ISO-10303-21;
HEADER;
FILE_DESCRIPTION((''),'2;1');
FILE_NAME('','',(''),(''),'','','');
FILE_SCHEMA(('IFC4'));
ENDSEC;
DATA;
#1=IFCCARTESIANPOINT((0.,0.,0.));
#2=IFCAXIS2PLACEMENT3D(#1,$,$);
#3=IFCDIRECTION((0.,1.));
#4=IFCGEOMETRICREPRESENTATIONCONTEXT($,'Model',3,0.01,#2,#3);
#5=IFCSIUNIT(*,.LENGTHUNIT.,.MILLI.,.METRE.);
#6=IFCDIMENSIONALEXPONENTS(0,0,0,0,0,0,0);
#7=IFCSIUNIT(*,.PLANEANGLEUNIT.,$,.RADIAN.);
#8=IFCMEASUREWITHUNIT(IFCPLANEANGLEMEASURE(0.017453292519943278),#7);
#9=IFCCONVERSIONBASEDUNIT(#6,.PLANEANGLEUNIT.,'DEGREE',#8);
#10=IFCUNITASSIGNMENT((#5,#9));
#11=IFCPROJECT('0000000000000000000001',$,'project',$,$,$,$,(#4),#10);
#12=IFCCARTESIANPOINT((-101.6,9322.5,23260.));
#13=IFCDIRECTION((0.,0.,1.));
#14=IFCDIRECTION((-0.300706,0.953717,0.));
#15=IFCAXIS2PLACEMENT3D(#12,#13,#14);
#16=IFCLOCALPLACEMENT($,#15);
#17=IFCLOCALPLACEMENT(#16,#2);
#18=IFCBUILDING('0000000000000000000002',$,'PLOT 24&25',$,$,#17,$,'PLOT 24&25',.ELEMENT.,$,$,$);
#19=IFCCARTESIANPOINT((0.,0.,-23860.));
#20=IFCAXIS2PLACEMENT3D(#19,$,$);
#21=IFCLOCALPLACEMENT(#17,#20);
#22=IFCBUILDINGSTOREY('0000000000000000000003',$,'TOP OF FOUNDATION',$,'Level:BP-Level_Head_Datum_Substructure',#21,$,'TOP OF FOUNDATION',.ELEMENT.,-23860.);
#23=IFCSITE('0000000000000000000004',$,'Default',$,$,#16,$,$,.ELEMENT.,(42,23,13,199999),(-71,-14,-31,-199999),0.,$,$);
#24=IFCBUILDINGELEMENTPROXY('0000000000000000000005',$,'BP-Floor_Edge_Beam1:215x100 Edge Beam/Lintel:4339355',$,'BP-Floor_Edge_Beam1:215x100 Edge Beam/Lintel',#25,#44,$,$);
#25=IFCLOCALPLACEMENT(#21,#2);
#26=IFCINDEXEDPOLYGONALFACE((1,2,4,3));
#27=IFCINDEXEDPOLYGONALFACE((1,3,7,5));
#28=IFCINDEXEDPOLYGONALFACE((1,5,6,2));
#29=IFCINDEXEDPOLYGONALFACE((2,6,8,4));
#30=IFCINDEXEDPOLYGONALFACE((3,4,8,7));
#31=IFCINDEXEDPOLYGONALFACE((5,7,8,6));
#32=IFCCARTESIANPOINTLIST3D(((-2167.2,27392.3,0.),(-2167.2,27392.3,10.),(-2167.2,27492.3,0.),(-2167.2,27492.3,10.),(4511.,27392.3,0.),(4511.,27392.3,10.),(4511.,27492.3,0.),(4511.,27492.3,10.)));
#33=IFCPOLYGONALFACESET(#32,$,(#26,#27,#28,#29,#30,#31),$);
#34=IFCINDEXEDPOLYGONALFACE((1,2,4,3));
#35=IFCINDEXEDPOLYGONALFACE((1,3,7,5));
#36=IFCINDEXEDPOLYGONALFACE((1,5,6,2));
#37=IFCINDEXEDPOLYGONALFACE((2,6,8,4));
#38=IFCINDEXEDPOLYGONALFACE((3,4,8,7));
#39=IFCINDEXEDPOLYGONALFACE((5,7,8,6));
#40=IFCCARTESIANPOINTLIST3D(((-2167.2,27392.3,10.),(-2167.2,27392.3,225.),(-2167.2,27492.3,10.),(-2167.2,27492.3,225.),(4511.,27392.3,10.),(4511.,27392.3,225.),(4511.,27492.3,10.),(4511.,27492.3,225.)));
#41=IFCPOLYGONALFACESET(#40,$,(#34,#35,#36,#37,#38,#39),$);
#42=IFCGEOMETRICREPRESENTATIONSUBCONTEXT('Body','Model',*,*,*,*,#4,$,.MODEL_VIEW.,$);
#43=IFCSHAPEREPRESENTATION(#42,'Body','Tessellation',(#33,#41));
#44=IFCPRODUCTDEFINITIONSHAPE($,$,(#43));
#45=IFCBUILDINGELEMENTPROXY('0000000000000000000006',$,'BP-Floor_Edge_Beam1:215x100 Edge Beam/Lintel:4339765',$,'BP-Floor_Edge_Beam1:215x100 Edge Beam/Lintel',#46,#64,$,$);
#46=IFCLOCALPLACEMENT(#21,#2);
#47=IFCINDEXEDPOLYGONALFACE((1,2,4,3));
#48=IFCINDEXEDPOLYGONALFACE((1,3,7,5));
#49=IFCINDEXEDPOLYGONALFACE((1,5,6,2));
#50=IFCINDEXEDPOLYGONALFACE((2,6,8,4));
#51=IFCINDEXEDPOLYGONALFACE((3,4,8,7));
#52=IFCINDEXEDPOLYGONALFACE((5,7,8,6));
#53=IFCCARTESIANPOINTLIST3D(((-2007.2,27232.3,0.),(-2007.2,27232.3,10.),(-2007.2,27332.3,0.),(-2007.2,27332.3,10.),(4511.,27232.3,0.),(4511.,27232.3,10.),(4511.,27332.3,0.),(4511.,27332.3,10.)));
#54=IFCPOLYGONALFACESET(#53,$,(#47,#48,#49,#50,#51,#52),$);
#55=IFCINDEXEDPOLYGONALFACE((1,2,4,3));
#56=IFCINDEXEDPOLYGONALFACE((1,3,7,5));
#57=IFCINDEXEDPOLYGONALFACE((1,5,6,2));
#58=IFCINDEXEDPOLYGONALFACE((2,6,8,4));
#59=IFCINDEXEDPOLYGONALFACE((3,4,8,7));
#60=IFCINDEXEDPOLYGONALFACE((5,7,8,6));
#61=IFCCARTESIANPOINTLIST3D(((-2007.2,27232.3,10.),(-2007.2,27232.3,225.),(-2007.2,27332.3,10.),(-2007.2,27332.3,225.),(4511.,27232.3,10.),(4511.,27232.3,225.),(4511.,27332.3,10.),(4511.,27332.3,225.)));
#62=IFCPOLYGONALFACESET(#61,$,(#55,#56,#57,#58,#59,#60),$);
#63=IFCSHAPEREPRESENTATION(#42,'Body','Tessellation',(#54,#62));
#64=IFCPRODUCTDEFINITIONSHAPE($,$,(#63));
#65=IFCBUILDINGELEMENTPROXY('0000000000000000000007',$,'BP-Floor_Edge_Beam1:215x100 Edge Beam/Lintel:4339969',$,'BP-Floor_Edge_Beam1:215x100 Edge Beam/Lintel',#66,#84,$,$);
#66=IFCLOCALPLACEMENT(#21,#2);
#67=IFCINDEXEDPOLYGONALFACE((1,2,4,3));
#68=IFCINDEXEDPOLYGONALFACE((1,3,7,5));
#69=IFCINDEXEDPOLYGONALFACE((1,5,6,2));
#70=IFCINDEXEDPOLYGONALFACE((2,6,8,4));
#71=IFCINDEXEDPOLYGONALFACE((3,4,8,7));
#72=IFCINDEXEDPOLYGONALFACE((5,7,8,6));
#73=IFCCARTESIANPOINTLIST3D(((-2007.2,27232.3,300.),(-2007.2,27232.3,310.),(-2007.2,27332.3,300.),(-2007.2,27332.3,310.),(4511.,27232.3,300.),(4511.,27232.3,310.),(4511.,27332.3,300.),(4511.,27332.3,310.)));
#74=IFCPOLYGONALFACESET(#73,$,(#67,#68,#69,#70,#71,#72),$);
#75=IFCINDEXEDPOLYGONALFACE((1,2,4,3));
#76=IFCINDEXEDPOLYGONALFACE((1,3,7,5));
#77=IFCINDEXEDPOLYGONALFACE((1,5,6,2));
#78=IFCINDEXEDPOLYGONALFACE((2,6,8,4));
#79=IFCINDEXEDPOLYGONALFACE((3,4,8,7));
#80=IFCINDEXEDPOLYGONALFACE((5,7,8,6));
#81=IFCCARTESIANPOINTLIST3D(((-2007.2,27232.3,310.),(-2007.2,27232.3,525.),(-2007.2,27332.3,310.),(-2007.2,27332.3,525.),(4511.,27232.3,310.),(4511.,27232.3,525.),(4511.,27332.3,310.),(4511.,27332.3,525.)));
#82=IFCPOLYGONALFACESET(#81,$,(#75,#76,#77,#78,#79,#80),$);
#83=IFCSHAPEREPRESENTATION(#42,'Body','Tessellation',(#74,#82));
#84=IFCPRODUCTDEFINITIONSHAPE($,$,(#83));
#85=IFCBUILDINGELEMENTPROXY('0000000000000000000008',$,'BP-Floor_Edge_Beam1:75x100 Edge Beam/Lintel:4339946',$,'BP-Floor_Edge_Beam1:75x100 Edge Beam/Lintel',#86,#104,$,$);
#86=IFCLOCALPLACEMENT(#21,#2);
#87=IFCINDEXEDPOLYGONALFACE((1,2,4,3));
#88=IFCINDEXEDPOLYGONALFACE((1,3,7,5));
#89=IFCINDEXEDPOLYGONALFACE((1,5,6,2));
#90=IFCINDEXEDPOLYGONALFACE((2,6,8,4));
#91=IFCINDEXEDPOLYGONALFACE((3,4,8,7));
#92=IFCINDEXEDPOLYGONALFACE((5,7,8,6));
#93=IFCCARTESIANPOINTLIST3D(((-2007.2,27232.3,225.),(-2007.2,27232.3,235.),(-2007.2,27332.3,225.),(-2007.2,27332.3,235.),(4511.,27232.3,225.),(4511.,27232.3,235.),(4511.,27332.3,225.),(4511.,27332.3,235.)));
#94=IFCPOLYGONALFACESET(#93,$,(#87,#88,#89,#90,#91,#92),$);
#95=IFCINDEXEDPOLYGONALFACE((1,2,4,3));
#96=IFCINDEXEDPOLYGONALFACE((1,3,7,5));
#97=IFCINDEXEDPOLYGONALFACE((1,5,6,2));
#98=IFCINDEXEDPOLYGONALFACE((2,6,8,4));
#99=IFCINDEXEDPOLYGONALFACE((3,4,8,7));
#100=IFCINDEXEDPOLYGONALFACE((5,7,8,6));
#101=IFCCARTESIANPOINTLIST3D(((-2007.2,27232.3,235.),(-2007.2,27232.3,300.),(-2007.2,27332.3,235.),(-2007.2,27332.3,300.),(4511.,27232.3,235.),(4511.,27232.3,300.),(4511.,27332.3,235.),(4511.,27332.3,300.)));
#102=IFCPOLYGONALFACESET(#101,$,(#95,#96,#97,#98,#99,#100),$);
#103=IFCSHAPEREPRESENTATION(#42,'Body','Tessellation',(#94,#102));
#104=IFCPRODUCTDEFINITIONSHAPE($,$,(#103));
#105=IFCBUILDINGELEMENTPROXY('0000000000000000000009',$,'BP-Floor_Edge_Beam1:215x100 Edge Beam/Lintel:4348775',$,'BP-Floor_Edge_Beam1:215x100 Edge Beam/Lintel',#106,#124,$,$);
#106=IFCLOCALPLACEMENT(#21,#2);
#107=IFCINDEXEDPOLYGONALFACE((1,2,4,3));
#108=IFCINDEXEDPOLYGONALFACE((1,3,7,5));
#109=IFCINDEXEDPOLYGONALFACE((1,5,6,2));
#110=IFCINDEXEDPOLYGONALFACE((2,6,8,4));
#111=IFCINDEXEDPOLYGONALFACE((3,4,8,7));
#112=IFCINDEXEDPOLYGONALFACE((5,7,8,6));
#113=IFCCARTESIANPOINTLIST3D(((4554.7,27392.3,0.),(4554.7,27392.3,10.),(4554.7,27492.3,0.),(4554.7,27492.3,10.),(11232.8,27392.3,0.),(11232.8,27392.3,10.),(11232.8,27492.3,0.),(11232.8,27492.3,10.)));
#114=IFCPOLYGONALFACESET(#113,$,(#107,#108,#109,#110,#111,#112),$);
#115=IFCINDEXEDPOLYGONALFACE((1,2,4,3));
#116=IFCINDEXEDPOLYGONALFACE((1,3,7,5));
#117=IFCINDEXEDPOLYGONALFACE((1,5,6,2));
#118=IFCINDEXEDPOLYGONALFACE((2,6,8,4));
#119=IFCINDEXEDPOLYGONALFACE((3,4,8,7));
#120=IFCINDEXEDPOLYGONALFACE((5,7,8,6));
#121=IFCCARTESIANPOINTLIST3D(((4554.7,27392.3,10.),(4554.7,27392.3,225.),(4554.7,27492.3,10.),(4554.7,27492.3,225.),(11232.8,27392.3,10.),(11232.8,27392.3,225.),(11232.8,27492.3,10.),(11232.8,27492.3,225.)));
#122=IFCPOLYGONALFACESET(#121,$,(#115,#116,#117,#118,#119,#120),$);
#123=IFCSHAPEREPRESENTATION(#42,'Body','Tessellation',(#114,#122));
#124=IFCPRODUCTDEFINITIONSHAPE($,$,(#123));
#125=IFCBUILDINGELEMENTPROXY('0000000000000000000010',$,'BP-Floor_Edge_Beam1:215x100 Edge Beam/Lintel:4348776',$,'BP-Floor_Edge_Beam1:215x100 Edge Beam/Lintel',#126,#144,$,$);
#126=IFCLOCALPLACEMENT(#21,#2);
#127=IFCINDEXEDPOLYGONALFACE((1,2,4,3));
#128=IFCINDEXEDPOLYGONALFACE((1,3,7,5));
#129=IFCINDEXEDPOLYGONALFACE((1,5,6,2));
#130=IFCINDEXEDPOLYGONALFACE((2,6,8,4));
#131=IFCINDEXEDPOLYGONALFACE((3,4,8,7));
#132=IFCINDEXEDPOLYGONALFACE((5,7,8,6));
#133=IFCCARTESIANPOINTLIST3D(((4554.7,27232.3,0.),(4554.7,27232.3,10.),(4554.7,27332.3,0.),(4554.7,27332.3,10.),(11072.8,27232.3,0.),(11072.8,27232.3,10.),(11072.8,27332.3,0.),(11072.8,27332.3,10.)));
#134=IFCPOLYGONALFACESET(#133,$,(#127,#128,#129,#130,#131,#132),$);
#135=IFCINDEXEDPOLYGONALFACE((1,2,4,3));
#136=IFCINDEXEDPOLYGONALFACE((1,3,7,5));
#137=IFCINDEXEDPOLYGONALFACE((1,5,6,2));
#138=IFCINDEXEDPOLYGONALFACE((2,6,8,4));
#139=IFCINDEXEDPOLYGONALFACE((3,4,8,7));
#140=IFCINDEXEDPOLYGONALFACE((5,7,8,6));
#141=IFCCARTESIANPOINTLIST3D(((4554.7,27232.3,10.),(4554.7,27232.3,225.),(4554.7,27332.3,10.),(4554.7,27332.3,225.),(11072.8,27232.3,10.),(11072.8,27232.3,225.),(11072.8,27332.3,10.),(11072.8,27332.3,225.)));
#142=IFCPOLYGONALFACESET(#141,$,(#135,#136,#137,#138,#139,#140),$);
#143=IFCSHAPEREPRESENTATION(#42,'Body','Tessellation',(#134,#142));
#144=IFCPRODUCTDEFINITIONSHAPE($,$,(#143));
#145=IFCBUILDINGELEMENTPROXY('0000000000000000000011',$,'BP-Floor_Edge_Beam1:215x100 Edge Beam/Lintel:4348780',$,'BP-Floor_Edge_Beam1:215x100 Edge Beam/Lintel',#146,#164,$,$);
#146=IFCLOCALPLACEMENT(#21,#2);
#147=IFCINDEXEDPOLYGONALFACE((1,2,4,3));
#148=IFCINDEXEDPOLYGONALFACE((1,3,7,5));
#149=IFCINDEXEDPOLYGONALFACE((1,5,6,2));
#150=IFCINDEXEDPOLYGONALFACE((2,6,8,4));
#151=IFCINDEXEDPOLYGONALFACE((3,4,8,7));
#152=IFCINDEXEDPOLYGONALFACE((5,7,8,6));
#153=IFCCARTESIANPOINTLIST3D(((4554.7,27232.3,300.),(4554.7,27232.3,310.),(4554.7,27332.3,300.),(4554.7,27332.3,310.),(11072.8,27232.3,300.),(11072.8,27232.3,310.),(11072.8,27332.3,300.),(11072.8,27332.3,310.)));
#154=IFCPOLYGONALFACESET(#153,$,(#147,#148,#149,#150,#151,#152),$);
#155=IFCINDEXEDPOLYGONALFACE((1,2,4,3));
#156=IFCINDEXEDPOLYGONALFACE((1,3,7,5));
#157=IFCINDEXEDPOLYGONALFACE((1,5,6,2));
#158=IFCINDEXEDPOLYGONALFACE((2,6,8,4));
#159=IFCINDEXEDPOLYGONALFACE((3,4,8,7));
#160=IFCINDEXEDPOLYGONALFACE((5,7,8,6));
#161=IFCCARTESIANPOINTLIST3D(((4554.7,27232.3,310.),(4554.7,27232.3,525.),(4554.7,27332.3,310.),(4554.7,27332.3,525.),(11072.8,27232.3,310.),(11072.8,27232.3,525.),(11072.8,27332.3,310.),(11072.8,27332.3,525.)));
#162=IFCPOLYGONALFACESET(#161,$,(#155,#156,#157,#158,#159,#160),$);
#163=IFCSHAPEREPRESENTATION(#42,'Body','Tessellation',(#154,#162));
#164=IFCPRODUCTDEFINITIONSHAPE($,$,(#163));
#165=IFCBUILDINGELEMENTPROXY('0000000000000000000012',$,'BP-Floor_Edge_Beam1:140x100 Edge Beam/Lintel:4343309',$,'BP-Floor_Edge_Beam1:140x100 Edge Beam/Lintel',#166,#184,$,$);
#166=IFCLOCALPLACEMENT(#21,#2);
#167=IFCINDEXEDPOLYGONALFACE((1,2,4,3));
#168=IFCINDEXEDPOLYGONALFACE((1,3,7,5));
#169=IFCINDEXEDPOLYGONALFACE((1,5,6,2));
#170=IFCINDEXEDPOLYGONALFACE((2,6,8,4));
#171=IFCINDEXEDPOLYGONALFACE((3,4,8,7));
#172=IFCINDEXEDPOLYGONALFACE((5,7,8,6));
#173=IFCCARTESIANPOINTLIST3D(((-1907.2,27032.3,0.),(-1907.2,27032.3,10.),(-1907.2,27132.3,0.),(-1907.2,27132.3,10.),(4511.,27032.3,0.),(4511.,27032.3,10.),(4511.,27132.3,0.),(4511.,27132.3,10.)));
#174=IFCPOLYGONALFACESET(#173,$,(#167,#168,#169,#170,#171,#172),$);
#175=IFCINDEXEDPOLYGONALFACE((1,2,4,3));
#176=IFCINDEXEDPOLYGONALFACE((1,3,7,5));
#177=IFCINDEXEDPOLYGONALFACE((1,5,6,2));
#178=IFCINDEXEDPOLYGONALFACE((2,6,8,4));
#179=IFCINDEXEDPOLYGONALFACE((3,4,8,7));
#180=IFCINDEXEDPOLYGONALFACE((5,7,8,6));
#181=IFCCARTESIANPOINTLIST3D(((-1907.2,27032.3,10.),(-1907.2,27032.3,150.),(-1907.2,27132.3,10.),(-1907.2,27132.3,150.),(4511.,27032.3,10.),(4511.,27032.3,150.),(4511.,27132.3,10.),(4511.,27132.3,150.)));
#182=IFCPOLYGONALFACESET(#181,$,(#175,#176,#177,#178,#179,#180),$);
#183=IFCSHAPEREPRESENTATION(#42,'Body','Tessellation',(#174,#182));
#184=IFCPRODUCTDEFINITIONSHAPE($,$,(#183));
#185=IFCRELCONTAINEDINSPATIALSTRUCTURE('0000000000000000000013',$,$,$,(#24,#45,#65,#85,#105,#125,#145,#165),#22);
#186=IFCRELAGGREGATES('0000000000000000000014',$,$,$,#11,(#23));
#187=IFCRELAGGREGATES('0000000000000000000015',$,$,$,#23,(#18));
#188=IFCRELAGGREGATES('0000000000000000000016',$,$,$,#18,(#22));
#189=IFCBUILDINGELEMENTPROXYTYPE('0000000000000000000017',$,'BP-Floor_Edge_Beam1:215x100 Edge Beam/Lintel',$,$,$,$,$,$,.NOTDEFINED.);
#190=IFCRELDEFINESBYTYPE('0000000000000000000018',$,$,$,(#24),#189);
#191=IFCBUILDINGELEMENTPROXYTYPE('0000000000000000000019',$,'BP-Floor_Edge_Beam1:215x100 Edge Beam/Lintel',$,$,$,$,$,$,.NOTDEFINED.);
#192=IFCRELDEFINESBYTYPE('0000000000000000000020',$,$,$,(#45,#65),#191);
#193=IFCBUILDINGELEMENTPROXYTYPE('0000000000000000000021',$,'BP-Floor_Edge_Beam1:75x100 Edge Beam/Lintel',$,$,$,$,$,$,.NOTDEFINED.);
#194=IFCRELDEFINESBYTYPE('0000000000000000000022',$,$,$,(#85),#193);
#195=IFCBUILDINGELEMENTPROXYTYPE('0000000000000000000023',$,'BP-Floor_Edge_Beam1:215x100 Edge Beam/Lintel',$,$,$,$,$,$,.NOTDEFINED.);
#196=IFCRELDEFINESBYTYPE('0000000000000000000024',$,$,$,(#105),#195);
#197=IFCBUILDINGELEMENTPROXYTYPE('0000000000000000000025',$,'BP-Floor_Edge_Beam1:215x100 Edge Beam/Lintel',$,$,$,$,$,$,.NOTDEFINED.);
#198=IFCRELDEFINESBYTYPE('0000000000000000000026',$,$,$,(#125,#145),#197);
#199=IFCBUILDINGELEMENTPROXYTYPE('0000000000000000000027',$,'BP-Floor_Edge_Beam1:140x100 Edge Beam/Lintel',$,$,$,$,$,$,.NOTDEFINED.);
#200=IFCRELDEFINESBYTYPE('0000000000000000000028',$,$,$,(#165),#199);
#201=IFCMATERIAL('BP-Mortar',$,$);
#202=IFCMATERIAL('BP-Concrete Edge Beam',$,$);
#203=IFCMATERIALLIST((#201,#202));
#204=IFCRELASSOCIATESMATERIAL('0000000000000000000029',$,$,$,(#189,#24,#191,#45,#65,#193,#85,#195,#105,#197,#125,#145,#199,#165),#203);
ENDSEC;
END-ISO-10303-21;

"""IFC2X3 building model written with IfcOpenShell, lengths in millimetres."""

from ifc_helpers import new_model, entity, si_unit, converted_unit, direction, frame, frame_2d, origin, origin_2d_with_axis, place, context, subcontext, project, spatial, rectangle, extrude, source, transform, mapped, material, material_list, type_object, type_shapes, element, save


model = new_model("IFC2X3")

# Units and contexts
model_context = context("Model", 3, precision=0.01, world=origin(), true_north=direction((0.0, 1.0)))
body_context = subcontext(model_context, "Body", "Model", "MODEL_VIEW")
ifc_project = project(units=[si_unit("LENGTHUNIT", "METRE", prefix="MILLI"), converted_unit("PLANEANGLEUNIT", "DEGREE", entity("IfcPlaneAngleMeasure", 0.017453292519943278), si_unit("PLANEANGLEUNIT", "RADIAN"), dimensions=[0, 0, 0, 0, 0, 0, 0])], contexts=[model_context])

# Site, building, storey
site_placement = place(None, frame((-101.6, 9322.5, 23260.0), z_axis=(0.0, 0.0, 1.0), x_axis=(-0.300706, 0.953717, 0.0)))
site = spatial("IfcSite", under=ifc_project, at=site_placement, Name="Default", CompositionType="ELEMENT", RefLatitude=(42, 23, 13, 199999), RefLongitude=(-71, -14, -31, -199999), RefElevation=0.0)
building_placement = place(site_placement, origin())
building = spatial("IfcBuilding", under=site, at=building_placement, Name="PLOT 24&25", LongName="PLOT 24&25", CompositionType="ELEMENT")
storey_placement = place(building_placement, frame((0.0, 0.0, -23860.0)))
storey = spatial("IfcBuildingStorey", under=building, at=storey_placement, Name="TOP OF FOUNDATION", ObjectType="Level:BP-Level_Head_Datum_Substructure", LongName="TOP OF FOUNDATION", CompositionType="ELEMENT", Elevation=-23860.0)

# Building element proxies
ifc_material_1 = material(Name="BP-Mortar")
ifc_material_2 = material(Name="BP-Concrete Edge Beam")
ifc_material_list = material_list([ifc_material_1, ifc_material_2])
building_element_proxy_type_1 = type_object("IfcBuildingElementProxyType", Name="BP-Floor_Edge_Beam1:215x100 Edge Beam/Lintel", PredefinedType="NOTDEFINED", material=ifc_material_list)
shared_shape_1 = source(origin(), body_context, "Body", "SweptSolid", [
    extrude(rectangle(XDim=6678.2, YDim=100.0, at=frame_2d((0.0, 0.0), x_axis=(1.0, 0.0))), frame((0.0, 0.0, 0.0), z_axis=(0.0, 0.0, 1.0), x_axis=(-1.0, 0.0, 0.0)), (0.0, 0.0, 1.0), 10.0),
    extrude(rectangle(XDim=6678.2, YDim=100.0, at=origin_2d_with_axis()), frame((0.0, 0.0, 10.0), z_axis=(0.0, 0.0, 1.0), x_axis=(-1.0, 0.0, 0.0)), (0.0, 0.0, 1.0), 215.0),
])
type_shapes(building_element_proxy_type_1, [shared_shape_1])
proxy_1_placement = place(storey_placement, frame((1171.9, 27442.3, 0.0)))
element("IfcBuildingElementProxy", 1, at=proxy_1_placement, inside=storey, type_object=building_element_proxy_type_1, material=ifc_material_list, Name="BP-Floor_Edge_Beam1:215x100 Edge Beam/Lintel:4339355", ObjectType="BP-Floor_Edge_Beam1:215x100 Edge Beam/Lintel", context=body_context, shape_type="MappedRepresentation", body=[
    mapped(shared_shape_1, transform((0.0, 0.0, 0.0), scale=1.0)),
])
building_element_proxy_type_2 = type_object("IfcBuildingElementProxyType", Name="BP-Floor_Edge_Beam1:215x100 Edge Beam/Lintel", PredefinedType="NOTDEFINED", material=ifc_material_list)
shared_shape_2 = source(origin(), body_context, "Body", "SweptSolid", [
    extrude(rectangle(XDim=6518.2, YDim=100.0, at=frame_2d((0.0, 0.0), x_axis=(1.0, 0.0))), frame((0.0, 0.0, 0.0), z_axis=(0.0, 0.0, 1.0), x_axis=(-1.0, 0.0, 0.0)), (0.0, 0.0, 1.0), 10.0),
    extrude(rectangle(XDim=6518.2, YDim=100.0, at=origin_2d_with_axis()), frame((0.0, 0.0, 10.0), z_axis=(0.0, 0.0, 1.0), x_axis=(-1.0, 0.0, 0.0)), (0.0, 0.0, 1.0), 215.0),
])
type_shapes(building_element_proxy_type_2, [shared_shape_2])
for number, where, name in (
    (2, (1251.9, 27282.3, 0.0), "BP-Floor_Edge_Beam1:215x100 Edge Beam/Lintel:4339765"),
    (3, (1251.9, 27282.3, 300.0), "BP-Floor_Edge_Beam1:215x100 Edge Beam/Lintel:4339969"),
):
    element("IfcBuildingElementProxy", number, at=place(storey_placement, frame(where)), inside=storey, type_object=building_element_proxy_type_2, material=ifc_material_list, Name=name, ObjectType="BP-Floor_Edge_Beam1:215x100 Edge Beam/Lintel", context=body_context, shape_type="MappedRepresentation", body=[
        mapped(shared_shape_2, transform((0.0, 0.0, 0.0), scale=1.0)),
    ])
building_element_proxy_type_3 = type_object("IfcBuildingElementProxyType", Name="BP-Floor_Edge_Beam1:75x100 Edge Beam/Lintel", PredefinedType="NOTDEFINED", material=ifc_material_list)
shared_shape_3 = source(origin(), body_context, "Body", "SweptSolid", [
    extrude(rectangle(XDim=6518.2, YDim=100.0, at=frame_2d((0.0, 0.0), x_axis=(1.0, 0.0))), frame((0.0, 0.0, 0.0), z_axis=(0.0, 0.0, 1.0), x_axis=(-1.0, 0.0, 0.0)), (0.0, 0.0, 1.0), 10.0),
    extrude(rectangle(XDim=6518.2, YDim=100.0, at=origin_2d_with_axis()), frame((0.0, 0.0, 10.0), z_axis=(0.0, 0.0, 1.0), x_axis=(-1.0, 0.0, 0.0)), (0.0, 0.0, 1.0), 65.0),
])
type_shapes(building_element_proxy_type_3, [shared_shape_3])
proxy_2_placement = place(storey_placement, frame((1251.9, 27282.3, 225.0)))
element("IfcBuildingElementProxy", 4, at=proxy_2_placement, inside=storey, type_object=building_element_proxy_type_3, material=ifc_material_list, Name="BP-Floor_Edge_Beam1:75x100 Edge Beam/Lintel:4339946", ObjectType="BP-Floor_Edge_Beam1:75x100 Edge Beam/Lintel", context=body_context, shape_type="MappedRepresentation", body=[
    mapped(shared_shape_3, transform((0.0, 0.0, 0.0), scale=1.0)),
])
building_element_proxy_type_4 = type_object("IfcBuildingElementProxyType", Name="BP-Floor_Edge_Beam1:215x100 Edge Beam/Lintel", PredefinedType="NOTDEFINED", material=ifc_material_list)
shared_shape_4 = source(origin(), body_context, "Body", "SweptSolid", [
    extrude(rectangle(XDim=100.0, YDim=6678.2, at=frame_2d((0.0, 0.0), x_axis=(1.0, 0.0))), frame((0.0, 0.0, 0.0), z_axis=(0.0, 0.0, 1.0), x_axis=(0.0, 1.0, 0.0)), (0.0, 0.0, 1.0), 10.0),
    extrude(rectangle(XDim=100.0, YDim=6678.2, at=origin_2d_with_axis()), frame((0.0, 0.0, 10.0), z_axis=(0.0, 0.0, 1.0), x_axis=(0.0, 1.0, 0.0)), (0.0, 0.0, 1.0), 215.0),
])
type_shapes(building_element_proxy_type_4, [shared_shape_4])
proxy_3_placement = place(storey_placement, frame((7893.8, 27442.3, 0.0), z_axis=(0.0, 0.0, 1.0), x_axis=(-1.0, 0.0, 0.0)))
element("IfcBuildingElementProxy", 5, at=proxy_3_placement, inside=storey, type_object=building_element_proxy_type_4, material=ifc_material_list, Name="BP-Floor_Edge_Beam1:215x100 Edge Beam/Lintel:4348775", ObjectType="BP-Floor_Edge_Beam1:215x100 Edge Beam/Lintel", context=body_context, shape_type="MappedRepresentation", body=[
    mapped(shared_shape_4, transform((0.0, 0.0, 0.0), scale=1.0)),
])
building_element_proxy_type_5 = type_object("IfcBuildingElementProxyType", Name="BP-Floor_Edge_Beam1:215x100 Edge Beam/Lintel", PredefinedType="NOTDEFINED", material=ifc_material_list)
shared_shape_5 = source(origin(), body_context, "Body", "SweptSolid", [
    extrude(rectangle(XDim=100.0, YDim=6518.2, at=frame_2d((0.0, 0.0), x_axis=(1.0, 0.0))), frame((0.0, 0.0, 0.0), z_axis=(0.0, 0.0, 1.0), x_axis=(0.0, 1.0, 0.0)), (0.0, 0.0, 1.0), 10.0),
    extrude(rectangle(XDim=100.0, YDim=6518.2, at=origin_2d_with_axis()), frame((0.0, 0.0, 10.0), z_axis=(0.0, 0.0, 1.0), x_axis=(0.0, 1.0, 0.0)), (0.0, 0.0, 1.0), 215.0),
])
type_shapes(building_element_proxy_type_5, [shared_shape_5])
for number, where, z_axis, x_axis, name in (
    (6, (7813.8, 27282.3, 0.0), (0.0, 0.0, 1.0), (-1.0, 0.0, 0.0), "BP-Floor_Edge_Beam1:215x100 Edge Beam/Lintel:4348776"),
    (7, (7813.8, 27282.3, 300.0), (0.0, 0.0, 1.0), (-1.0, 0.0, 0.0), "BP-Floor_Edge_Beam1:215x100 Edge Beam/Lintel:4348780"),
):
    element("IfcBuildingElementProxy", number, at=place(storey_placement, frame(where, z_axis=z_axis, x_axis=x_axis)), inside=storey, type_object=building_element_proxy_type_5, material=ifc_material_list, Name=name, ObjectType="BP-Floor_Edge_Beam1:215x100 Edge Beam/Lintel", context=body_context, shape_type="MappedRepresentation", body=[
        mapped(shared_shape_5, transform((0.0, 0.0, 0.0), scale=1.0)),
    ])
building_element_proxy_type_6 = type_object("IfcBuildingElementProxyType", Name="BP-Floor_Edge_Beam1:140x100 Edge Beam/Lintel", PredefinedType="NOTDEFINED", material=ifc_material_list)
shared_shape_6 = source(origin(), body_context, "Body", "SweptSolid", [
    extrude(rectangle(XDim=100.0, YDim=6418.2, at=frame_2d((0.0, 0.0), x_axis=(1.0, 0.0))), frame((0.0, 0.0, 0.0), z_axis=(0.0, 0.0, 1.0), x_axis=(0.0, 1.0, 0.0)), (0.0, 0.0, 1.0), 10.0),
    extrude(rectangle(XDim=100.0, YDim=6418.2, at=origin_2d_with_axis()), frame((0.0, 0.0, 10.0), z_axis=(0.0, 0.0, 1.0), x_axis=(0.0, 1.0, 0.0)), (0.0, 0.0, 1.0), 140.0),
])
type_shapes(building_element_proxy_type_6, [shared_shape_6])
proxy_4_placement = place(storey_placement, frame((1301.9, 27082.3, 0.0)))
element("IfcBuildingElementProxy", 8, at=proxy_4_placement, inside=storey, type_object=building_element_proxy_type_6, material=ifc_material_list, Name="BP-Floor_Edge_Beam1:140x100 Edge Beam/Lintel:4343309", ObjectType="BP-Floor_Edge_Beam1:140x100 Edge Beam/Lintel", context=body_context, shape_type="MappedRepresentation", body=[
    mapped(shared_shape_6, transform((0.0, 0.0, 0.0), scale=1.0)),
])

save(model, "model.ifc")
